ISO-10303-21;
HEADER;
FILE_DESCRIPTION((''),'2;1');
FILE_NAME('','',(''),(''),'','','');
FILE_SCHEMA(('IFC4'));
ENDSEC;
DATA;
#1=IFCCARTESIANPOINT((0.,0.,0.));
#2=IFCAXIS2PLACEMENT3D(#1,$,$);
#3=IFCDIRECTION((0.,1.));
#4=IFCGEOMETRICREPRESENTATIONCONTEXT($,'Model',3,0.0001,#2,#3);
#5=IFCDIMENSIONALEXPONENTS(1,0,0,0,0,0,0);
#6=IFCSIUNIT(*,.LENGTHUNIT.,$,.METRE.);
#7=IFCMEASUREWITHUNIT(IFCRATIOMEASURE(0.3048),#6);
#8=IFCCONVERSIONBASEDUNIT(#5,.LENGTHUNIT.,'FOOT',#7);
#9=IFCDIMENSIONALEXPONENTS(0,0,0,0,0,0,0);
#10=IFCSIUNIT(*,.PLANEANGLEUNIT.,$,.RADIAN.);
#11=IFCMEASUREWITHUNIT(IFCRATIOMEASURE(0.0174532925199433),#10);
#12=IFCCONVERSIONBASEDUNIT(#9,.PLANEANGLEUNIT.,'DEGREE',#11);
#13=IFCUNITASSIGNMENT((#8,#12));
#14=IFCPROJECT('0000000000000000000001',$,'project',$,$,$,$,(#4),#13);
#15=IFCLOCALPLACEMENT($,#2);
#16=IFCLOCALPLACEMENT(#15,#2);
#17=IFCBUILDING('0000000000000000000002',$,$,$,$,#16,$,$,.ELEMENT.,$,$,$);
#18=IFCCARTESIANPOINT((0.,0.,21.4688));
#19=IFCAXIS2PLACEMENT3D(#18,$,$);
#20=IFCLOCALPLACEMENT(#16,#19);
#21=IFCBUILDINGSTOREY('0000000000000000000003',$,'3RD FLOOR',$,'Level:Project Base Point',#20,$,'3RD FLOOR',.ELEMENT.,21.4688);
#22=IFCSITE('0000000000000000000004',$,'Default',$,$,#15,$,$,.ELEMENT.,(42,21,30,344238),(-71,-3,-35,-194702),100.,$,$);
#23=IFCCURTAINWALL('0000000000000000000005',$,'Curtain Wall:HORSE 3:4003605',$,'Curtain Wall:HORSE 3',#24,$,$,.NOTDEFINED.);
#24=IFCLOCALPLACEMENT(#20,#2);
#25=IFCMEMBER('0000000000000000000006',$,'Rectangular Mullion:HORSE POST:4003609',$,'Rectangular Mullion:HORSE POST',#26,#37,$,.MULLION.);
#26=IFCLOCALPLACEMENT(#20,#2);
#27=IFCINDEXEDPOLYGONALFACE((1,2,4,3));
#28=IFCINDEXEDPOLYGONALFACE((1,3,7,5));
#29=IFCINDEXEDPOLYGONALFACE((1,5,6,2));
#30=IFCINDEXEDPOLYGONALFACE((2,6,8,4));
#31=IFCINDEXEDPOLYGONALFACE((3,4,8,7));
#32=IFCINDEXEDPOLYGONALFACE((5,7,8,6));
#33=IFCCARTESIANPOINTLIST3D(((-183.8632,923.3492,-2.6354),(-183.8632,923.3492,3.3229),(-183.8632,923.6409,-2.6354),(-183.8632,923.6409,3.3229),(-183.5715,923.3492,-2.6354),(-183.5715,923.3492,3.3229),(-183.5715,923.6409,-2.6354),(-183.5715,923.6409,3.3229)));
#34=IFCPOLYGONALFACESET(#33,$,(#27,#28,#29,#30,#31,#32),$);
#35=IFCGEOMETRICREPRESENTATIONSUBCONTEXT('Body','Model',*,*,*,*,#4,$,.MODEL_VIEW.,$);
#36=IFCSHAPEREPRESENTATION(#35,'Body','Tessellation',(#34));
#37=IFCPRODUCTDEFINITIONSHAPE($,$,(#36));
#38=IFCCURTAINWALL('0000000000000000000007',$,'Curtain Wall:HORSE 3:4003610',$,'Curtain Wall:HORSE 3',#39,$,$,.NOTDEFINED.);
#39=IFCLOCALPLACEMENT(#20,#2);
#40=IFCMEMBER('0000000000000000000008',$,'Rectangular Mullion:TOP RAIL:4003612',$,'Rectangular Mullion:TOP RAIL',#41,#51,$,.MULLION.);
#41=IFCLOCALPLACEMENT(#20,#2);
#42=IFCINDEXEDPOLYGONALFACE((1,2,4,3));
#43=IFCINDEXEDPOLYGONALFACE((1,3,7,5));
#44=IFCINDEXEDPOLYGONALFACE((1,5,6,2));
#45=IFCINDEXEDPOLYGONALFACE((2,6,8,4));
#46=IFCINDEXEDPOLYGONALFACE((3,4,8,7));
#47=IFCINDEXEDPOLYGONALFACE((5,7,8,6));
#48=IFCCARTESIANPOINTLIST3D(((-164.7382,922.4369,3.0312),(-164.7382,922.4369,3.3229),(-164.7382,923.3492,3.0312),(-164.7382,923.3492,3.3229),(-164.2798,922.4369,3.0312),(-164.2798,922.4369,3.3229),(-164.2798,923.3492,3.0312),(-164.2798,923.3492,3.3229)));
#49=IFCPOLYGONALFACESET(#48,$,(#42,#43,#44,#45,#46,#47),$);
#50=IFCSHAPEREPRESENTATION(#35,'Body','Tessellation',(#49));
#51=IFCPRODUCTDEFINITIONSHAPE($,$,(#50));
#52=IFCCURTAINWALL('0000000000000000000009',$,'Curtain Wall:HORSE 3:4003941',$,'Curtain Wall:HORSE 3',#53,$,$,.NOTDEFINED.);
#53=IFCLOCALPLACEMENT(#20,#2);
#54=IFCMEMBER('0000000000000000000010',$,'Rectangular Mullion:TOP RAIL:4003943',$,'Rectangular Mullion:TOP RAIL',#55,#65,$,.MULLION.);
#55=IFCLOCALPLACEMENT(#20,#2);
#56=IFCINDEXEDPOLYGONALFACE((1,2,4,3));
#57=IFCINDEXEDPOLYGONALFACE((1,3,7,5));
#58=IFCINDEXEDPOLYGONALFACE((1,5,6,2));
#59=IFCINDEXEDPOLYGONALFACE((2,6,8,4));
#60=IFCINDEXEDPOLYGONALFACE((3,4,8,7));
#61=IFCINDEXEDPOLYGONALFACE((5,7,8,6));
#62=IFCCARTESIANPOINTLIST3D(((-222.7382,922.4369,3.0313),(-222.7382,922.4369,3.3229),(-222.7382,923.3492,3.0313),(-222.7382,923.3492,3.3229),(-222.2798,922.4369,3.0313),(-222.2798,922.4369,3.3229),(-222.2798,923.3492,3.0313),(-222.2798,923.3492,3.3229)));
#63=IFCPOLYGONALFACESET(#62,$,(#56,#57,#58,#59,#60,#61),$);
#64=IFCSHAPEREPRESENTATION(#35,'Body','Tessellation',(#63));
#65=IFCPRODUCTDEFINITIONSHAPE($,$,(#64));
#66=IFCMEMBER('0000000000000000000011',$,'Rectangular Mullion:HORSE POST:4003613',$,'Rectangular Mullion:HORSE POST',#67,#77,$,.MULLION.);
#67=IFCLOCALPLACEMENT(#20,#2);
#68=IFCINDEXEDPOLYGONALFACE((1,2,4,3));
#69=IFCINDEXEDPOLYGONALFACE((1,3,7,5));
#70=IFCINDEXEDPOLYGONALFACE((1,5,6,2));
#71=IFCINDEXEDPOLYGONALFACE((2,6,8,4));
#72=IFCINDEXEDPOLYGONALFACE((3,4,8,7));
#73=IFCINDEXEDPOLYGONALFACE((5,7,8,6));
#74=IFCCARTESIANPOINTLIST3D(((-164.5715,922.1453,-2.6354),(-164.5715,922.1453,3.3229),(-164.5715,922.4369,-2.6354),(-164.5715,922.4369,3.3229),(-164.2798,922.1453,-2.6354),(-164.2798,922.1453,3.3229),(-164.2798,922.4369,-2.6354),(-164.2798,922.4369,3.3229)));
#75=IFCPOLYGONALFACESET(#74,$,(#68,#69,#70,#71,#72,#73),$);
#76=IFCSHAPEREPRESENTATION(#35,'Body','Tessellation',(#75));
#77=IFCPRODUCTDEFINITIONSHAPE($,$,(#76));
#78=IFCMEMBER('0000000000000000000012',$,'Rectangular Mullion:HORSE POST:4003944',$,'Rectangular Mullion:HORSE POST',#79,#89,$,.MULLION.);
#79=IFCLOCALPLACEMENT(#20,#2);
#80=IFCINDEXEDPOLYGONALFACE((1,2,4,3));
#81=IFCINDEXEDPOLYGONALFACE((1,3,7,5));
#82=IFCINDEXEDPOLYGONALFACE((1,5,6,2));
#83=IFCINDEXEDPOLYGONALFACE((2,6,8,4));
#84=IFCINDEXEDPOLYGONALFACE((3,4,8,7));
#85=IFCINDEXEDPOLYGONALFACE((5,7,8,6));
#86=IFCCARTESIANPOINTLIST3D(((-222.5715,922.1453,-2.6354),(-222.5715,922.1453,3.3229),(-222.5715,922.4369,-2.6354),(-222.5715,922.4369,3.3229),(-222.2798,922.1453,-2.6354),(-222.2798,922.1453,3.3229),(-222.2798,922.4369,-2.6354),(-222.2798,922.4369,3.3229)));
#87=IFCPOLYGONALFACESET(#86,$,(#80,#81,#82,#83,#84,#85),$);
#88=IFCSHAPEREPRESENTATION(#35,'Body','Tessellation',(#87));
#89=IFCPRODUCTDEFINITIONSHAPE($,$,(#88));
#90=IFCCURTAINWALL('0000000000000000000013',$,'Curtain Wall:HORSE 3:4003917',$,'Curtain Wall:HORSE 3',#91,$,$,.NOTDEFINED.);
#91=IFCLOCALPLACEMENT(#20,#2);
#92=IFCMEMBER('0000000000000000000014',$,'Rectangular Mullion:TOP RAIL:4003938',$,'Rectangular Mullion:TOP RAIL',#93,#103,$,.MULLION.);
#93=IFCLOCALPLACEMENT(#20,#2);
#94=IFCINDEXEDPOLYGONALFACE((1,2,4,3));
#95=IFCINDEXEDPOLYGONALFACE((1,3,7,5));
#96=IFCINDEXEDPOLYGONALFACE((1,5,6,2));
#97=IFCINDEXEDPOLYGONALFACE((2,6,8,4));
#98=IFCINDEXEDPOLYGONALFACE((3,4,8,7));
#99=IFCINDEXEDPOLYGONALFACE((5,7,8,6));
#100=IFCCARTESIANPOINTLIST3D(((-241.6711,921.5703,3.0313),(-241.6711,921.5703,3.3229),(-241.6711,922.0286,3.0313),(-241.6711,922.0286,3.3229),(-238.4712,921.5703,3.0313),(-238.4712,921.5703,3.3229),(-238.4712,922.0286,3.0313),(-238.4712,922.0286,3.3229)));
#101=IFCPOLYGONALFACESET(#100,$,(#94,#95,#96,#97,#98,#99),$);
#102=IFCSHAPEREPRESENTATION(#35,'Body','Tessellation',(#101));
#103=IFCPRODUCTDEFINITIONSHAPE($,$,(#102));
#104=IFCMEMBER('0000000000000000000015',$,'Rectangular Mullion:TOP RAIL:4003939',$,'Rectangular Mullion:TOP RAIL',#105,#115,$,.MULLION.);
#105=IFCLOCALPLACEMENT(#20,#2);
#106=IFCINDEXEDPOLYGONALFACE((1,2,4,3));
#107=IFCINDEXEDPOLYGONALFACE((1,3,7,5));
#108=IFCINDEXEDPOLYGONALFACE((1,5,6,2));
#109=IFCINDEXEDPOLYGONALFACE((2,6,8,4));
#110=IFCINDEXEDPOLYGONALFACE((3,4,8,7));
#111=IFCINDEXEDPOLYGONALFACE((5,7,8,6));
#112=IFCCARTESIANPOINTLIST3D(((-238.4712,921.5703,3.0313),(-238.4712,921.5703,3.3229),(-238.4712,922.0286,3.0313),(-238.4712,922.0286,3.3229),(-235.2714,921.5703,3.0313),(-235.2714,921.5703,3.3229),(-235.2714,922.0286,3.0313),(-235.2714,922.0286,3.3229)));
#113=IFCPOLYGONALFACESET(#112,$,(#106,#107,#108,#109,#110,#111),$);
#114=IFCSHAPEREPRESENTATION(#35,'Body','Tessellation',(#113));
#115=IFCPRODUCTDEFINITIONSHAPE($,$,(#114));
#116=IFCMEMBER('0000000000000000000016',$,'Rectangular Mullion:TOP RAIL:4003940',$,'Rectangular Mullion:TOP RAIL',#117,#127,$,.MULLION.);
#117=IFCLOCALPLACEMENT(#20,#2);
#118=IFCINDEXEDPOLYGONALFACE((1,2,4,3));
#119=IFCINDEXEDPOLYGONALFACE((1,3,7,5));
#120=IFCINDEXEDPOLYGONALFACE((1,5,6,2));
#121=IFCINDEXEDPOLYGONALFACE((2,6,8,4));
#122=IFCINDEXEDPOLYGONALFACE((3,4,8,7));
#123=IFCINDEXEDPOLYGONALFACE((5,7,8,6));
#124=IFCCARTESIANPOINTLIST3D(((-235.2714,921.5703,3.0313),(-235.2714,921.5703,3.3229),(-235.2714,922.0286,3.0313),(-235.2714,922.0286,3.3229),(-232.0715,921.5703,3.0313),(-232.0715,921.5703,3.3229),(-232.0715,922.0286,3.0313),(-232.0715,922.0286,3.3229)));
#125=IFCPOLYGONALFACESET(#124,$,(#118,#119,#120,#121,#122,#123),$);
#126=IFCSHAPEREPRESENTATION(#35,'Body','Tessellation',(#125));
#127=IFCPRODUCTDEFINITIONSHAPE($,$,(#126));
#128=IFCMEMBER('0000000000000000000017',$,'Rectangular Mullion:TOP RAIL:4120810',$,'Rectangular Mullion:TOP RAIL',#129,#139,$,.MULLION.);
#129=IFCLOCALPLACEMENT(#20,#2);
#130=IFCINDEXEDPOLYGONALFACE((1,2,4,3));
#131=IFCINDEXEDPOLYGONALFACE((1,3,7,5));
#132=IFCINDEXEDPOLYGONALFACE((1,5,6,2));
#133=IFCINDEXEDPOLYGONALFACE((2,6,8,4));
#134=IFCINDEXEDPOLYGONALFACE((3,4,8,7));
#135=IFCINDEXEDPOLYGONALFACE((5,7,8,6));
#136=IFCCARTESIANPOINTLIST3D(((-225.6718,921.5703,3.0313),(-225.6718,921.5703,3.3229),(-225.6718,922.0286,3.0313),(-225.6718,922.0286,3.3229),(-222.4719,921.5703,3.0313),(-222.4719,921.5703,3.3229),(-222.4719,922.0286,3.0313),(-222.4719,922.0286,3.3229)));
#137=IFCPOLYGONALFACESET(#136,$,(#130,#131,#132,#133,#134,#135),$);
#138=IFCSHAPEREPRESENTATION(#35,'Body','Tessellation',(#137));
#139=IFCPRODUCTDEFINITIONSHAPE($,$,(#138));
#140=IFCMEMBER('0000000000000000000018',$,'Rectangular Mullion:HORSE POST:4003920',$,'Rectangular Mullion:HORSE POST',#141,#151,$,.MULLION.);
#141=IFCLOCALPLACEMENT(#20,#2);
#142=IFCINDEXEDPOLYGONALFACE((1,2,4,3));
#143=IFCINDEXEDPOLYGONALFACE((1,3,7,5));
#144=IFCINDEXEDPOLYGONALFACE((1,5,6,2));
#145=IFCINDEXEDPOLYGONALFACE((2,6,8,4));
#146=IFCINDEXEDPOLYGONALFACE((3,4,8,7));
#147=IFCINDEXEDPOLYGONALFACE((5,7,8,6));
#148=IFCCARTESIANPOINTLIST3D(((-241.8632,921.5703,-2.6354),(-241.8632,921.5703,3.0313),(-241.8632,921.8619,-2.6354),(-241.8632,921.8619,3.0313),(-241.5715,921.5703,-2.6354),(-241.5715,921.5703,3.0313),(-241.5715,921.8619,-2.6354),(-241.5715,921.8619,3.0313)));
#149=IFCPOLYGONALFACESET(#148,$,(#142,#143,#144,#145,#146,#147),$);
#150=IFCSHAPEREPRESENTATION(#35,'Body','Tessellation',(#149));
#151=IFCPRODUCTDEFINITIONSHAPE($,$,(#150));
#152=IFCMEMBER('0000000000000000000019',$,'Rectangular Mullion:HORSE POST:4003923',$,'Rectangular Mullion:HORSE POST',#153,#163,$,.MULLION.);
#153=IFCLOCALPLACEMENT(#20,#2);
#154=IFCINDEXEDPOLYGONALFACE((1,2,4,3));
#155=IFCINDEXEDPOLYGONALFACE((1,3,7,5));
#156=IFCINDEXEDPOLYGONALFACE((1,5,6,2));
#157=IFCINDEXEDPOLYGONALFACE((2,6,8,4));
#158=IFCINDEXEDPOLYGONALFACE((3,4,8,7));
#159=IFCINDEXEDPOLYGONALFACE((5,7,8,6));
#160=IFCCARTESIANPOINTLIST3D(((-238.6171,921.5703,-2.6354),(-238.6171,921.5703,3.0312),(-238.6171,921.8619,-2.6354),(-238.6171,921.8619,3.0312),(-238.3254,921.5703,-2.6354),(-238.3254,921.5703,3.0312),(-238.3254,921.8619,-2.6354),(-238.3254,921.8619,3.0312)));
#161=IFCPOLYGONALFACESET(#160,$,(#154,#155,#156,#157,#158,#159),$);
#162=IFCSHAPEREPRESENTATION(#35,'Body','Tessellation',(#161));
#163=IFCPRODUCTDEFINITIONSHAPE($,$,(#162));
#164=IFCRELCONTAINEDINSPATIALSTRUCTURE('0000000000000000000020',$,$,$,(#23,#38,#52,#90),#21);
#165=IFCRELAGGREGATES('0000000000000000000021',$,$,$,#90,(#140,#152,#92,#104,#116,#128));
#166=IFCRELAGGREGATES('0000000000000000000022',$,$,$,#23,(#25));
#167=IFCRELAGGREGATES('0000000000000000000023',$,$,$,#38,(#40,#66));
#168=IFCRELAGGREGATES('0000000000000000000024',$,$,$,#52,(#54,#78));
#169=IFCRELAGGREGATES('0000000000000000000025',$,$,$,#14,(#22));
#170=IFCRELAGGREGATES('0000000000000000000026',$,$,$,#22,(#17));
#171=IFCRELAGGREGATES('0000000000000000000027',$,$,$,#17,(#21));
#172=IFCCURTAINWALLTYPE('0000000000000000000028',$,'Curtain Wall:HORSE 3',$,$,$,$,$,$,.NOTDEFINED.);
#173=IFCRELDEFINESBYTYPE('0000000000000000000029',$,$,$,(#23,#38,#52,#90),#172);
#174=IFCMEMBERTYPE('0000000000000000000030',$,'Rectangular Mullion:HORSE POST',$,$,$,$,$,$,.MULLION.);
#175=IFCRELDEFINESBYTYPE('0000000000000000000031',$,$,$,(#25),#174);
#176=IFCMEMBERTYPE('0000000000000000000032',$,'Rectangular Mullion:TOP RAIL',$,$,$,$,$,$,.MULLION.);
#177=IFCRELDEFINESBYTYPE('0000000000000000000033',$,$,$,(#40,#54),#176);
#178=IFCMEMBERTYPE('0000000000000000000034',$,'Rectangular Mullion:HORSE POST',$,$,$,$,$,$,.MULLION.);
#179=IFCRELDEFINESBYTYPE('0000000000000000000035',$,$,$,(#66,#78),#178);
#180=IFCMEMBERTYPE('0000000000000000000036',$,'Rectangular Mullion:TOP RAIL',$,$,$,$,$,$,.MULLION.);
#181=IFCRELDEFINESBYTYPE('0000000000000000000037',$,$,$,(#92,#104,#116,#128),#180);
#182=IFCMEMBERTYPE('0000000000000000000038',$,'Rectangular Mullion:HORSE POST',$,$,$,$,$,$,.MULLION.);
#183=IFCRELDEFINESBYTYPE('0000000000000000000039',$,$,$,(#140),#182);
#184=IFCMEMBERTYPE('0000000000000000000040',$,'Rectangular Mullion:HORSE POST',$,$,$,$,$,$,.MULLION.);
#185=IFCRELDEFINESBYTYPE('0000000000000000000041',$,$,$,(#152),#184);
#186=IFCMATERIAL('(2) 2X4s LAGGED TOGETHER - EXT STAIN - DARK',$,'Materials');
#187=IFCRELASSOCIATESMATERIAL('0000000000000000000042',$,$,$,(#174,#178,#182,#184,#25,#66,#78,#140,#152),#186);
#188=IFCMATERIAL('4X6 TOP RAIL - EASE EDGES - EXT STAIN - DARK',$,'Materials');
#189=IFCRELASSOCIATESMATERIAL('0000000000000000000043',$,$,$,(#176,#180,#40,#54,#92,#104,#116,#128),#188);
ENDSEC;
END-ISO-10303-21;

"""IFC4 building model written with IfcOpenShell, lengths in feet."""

from ifc_helpers import new_model, entity, si_unit, converted_unit, direction, frame, frame_2d, origin, origin_2d_with_axis, place, context, subcontext, project, spatial, rectangle, extrude, source, transform, mapped, material, material_profile, profile_set, profile_usage, type_object, type_shapes, element, aggregate, save


model = new_model("IFC4")

# Units and contexts
model_context = context("Model", 3, precision=0.0001, world=origin(), true_north=direction((0.0, 1.0)))
body_context = subcontext(model_context, "Body", "Model", "MODEL_VIEW")
ifc_project = project(units=[converted_unit("LENGTHUNIT", "FOOT", entity("IfcRatioMeasure", 0.3048), si_unit("LENGTHUNIT", "METRE"), dimensions=[1, 0, 0, 0, 0, 0, 0]), converted_unit("PLANEANGLEUNIT", "DEGREE", entity("IfcRatioMeasure", 0.0174532925199433), si_unit("PLANEANGLEUNIT", "RADIAN"), dimensions=[0, 0, 0, 0, 0, 0, 0])], contexts=[model_context])

# Site, building, storey
site_placement = place(None, origin())
site = spatial("IfcSite", under=ifc_project, at=site_placement, Name="Default", CompositionType="ELEMENT", RefLatitude=(42, 21, 30, 344238), RefLongitude=(-71, -3, -35, -194702), RefElevation=100.0)
building_placement = place(site_placement, origin())
building = spatial("IfcBuilding", under=site, at=building_placement, CompositionType="ELEMENT")
storey_placement = place(building_placement, frame((0.0, 0.0, 21.4688)))
storey = spatial("IfcBuildingStorey", under=building, at=storey_placement, Name="3RD FLOOR", ObjectType="Level:Project Base Point", LongName="3RD FLOOR", CompositionType="ELEMENT", Elevation=21.4688)

# Shared definitions
curtain_wall_type = type_object("IfcCurtainWallType", Name="Curtain Wall:HORSE 3", PredefinedType="NOTDEFINED")
ifc_material_1 = material(Name="(2) 2X4s LAGGED TOGETHER - EXT STAIN - DARK", Category="Materials")
ifc_material_profile_1 = material_profile(ifc_material_1, rectangle(XDim=0.2917, YDim=0.2917, at=frame_2d((0.0, 0.0), x_axis=(1.0, 0.0))), Name="HORSE POST")
ifc_profile_set_1 = profile_set([ifc_material_profile_1], Name="HORSE POST")
ifc_material_2 = material(Name="4X6 TOP RAIL - EASE EDGES - EXT STAIN - DARK", Category="Materials")
ifc_material_profile_2 = material_profile(ifc_material_2, rectangle(XDim=0.4583, YDim=0.2917, at=origin_2d_with_axis()), Name="TOP RAIL")
ifc_profile_set_2 = profile_set([ifc_material_profile_2], Name="TOP RAIL")

# Curtain wall
curtain_wall_1_placement = place(storey_placement, frame((0.0, 0.0, -21.4688)))
curtain_wall_1 = element("IfcCurtainWall", 1, at=curtain_wall_1_placement, inside=storey, type_object=curtain_wall_type, Name="Curtain Wall:HORSE 3:4003605", ObjectType="Curtain Wall:HORSE 3", PredefinedType="NOTDEFINED")

# Member
ifc_profile_usage_1 = profile_usage(ifc_profile_set_1)
member_type_1 = type_object("IfcMemberType", Name="Rectangular Mullion:HORSE POST", PredefinedType="MULLION", material=ifc_profile_set_1)
shared_shape_1 = source(origin(), body_context, "Body", "SweptSolid", [
    extrude(rectangle(XDim=0.2917, YDim=0.2917, at=origin_2d_with_axis()), frame((-0.1458, 0.1458, -5.9583), z_axis=(0.0, 0.0, 1.0), x_axis=(0.0, -1.0, 0.0)), (0.0, 0.0, 1.0), 5.9583),
])
type_shapes(member_type_1, [shared_shape_1])
member_1_placement = place(storey_placement, frame((-183.5715, 923.6409, 3.3229), z_axis=(0.0, 0.0, 1.0), x_axis=(0.0, 1.0, 0.0)))
member_1 = element("IfcMember", 2, at=member_1_placement, type_object=member_type_1, material=ifc_profile_usage_1, Name="Rectangular Mullion:HORSE POST:4003609", ObjectType="Rectangular Mullion:HORSE POST", PredefinedType="MULLION", context=body_context, shape_type="MappedRepresentation", body=[
    mapped(shared_shape_1, transform((0.0, 0.0, 0.0), scale=1.0)),
])

# Curtain walls, members
curtain_wall_2_placement = place(storey_placement, frame((0.0, 0.0, -21.4688)))
curtain_wall_2 = element("IfcCurtainWall", 3, at=curtain_wall_2_placement, inside=storey, type_object=curtain_wall_type, Name="Curtain Wall:HORSE 3:4003610", ObjectType="Curtain Wall:HORSE 3", PredefinedType="NOTDEFINED")
ifc_profile_usage_2 = profile_usage(ifc_profile_set_2)
member_type_2 = type_object("IfcMemberType", Name="Rectangular Mullion:TOP RAIL", PredefinedType="MULLION", material=ifc_profile_set_2)
shared_shape_2 = source(origin(), body_context, "Body", "SweptSolid", [
    extrude(rectangle(XDim=0.4583, YDim=0.2917, at=origin_2d_with_axis()), frame((-0.1458, -0.0625, -0.9123), z_axis=(0.0, 0.0, 1.0), x_axis=(0.0, -1.0, 0.0)), (0.0, 0.0, 1.0), 0.9123),
])
type_shapes(member_type_2, [shared_shape_2])
member_2_placement = place(storey_placement, frame((-164.5715, 922.4369, 3.3229), z_axis=(0.0, -1.0, 0.0), x_axis=(0.0, 0.0, 1.0)))
member_2 = element("IfcMember", 4, at=member_2_placement, type_object=member_type_2, material=ifc_profile_usage_2, Name="Rectangular Mullion:TOP RAIL:4003612", ObjectType="Rectangular Mullion:TOP RAIL", PredefinedType="MULLION", context=body_context, shape_type="MappedRepresentation", body=[
    mapped(shared_shape_2, transform((0.0, 0.0, 0.0), scale=1.0)),
])
curtain_wall_3_placement = place(storey_placement, frame((0.0, 0.0, -21.4688)))
curtain_wall_3 = element("IfcCurtainWall", 5, at=curtain_wall_3_placement, inside=storey, type_object=curtain_wall_type, Name="Curtain Wall:HORSE 3:4003941", ObjectType="Curtain Wall:HORSE 3", PredefinedType="NOTDEFINED")
ifc_profile_usage_3 = profile_usage(ifc_profile_set_2)
member_3_placement = place(storey_placement, frame((-222.5715, 922.4369, 3.3229), z_axis=(0.0, -1.0, 0.0), x_axis=(0.0, 0.0, 1.0)))
member_3 = element("IfcMember", 6, at=member_3_placement, type_object=member_type_2, material=ifc_profile_usage_3, Name="Rectangular Mullion:TOP RAIL:4003943", ObjectType="Rectangular Mullion:TOP RAIL", PredefinedType="MULLION", context=body_context, shape_type="MappedRepresentation", body=[
    mapped(shared_shape_2, transform((0.0, 0.0, 0.0), scale=1.0)),
])

# Members
ifc_profile_usage_4 = profile_usage(ifc_profile_set_1)
member_type_3 = type_object("IfcMemberType", Name="Rectangular Mullion:HORSE POST", PredefinedType="MULLION", material=ifc_profile_set_1)
shared_shape_3 = source(origin(), body_context, "Body", "SweptSolid", [
    extrude(rectangle(XDim=0.2917, YDim=0.2917, at=origin_2d_with_axis()), frame((-0.1458, -0.1458, -5.9583), z_axis=(0.0, 0.0, 1.0), x_axis=(0.0, -1.0, 0.0)), (0.0, 0.0, 1.0), 5.9583),
])
type_shapes(member_type_3, [shared_shape_3])
member_4_placement = place(storey_placement, frame((-164.5715, 922.1453, -2.6354), z_axis=(0.0, 0.0, -1.0), x_axis=(0.0, -1.0, 0.0)))
member_4 = element("IfcMember", 7, at=member_4_placement, type_object=member_type_3, material=ifc_profile_usage_4, Name="Rectangular Mullion:HORSE POST:4003613", ObjectType="Rectangular Mullion:HORSE POST", PredefinedType="MULLION", context=body_context, shape_type="MappedRepresentation", body=[
    mapped(shared_shape_3, transform((0.0, 0.0, 0.0), scale=1.0)),
])
ifc_profile_usage_5 = profile_usage(ifc_profile_set_1)
member_5_placement = place(storey_placement, frame((-222.5715, 922.1453, -2.6354), z_axis=(0.0, 0.0, -1.0), x_axis=(0.0, -1.0, 0.0)))
member_5 = element("IfcMember", 8, at=member_5_placement, type_object=member_type_3, material=ifc_profile_usage_5, Name="Rectangular Mullion:HORSE POST:4003944", ObjectType="Rectangular Mullion:HORSE POST", PredefinedType="MULLION", context=body_context, shape_type="MappedRepresentation", body=[
    mapped(shared_shape_3, transform((0.0, 0.0, 0.0), scale=1.0)),
])

# Curtain wall, members
curtain_wall_4_placement = place(storey_placement, frame((0.0, 0.0, -21.4688)))
curtain_wall_4 = element("IfcCurtainWall", 9, at=curtain_wall_4_placement, inside=storey, type_object=curtain_wall_type, Name="Curtain Wall:HORSE 3:4003917", ObjectType="Curtain Wall:HORSE 3", PredefinedType="NOTDEFINED")
ifc_profile_usage_6 = profile_usage(ifc_profile_set_2)
member_type_4 = type_object("IfcMemberType", Name="Rectangular Mullion:TOP RAIL", PredefinedType="MULLION", material=ifc_profile_set_2)
shared_shape_4 = source(origin(), body_context, "Body", "SweptSolid", [
    extrude(rectangle(XDim=0.4583, YDim=0.2917, at=origin_2d_with_axis()), frame((-0.1458, 0.0625, -3.1999), z_axis=(0.0, 0.0, 1.0), x_axis=(0.0, -1.0, 0.0)), (0.0, 0.0, 1.0), 3.1999),
])
type_shapes(member_type_4, [shared_shape_4])
member_6_placement = place(storey_placement, frame((-238.4712, 921.8619, 3.3229), z_axis=(1.0, 0.0, 0.0), x_axis=(0.0, 0.0, 1.0)))
member_6 = element("IfcMember", 10, at=member_6_placement, type_object=member_type_4, material=ifc_profile_usage_6, Name="Rectangular Mullion:TOP RAIL:4003938", ObjectType="Rectangular Mullion:TOP RAIL", PredefinedType="MULLION", context=body_context, shape_type="MappedRepresentation", body=[
    mapped(shared_shape_4, transform((0.0, 0.0, 0.0), scale=1.0)),
])
ifc_profile_usage_7 = profile_usage(ifc_profile_set_2)
member_7_placement = place(storey_placement, frame((-235.2714, 921.8619, 3.3229), z_axis=(1.0, 0.0, 0.0), x_axis=(0.0, 0.0, 1.0)))
member_7 = element("IfcMember", 11, at=member_7_placement, type_object=member_type_4, material=ifc_profile_usage_7, Name="Rectangular Mullion:TOP RAIL:4003939", ObjectType="Rectangular Mullion:TOP RAIL", PredefinedType="MULLION", context=body_context, shape_type="MappedRepresentation", body=[
    mapped(shared_shape_4, transform((0.0, 0.0, 0.0), scale=1.0)),
])
ifc_profile_usage_8 = profile_usage(ifc_profile_set_2)
member_8_placement = place(storey_placement, frame((-232.0715, 921.8619, 3.3229), z_axis=(1.0, 0.0, 0.0), x_axis=(0.0, 0.0, 1.0)))
member_8 = element("IfcMember", 12, at=member_8_placement, type_object=member_type_4, material=ifc_profile_usage_8, Name="Rectangular Mullion:TOP RAIL:4003940", ObjectType="Rectangular Mullion:TOP RAIL", PredefinedType="MULLION", context=body_context, shape_type="MappedRepresentation", body=[
    mapped(shared_shape_4, transform((0.0, 0.0, 0.0), scale=1.0)),
])
ifc_profile_usage_9 = profile_usage(ifc_profile_set_2)
member_9_placement = place(storey_placement, frame((-222.4719, 921.8619, 3.3229), z_axis=(1.0, 0.0, 0.0), x_axis=(0.0, 0.0, 1.0)))
member_9 = element("IfcMember", 13, at=member_9_placement, type_object=member_type_4, material=ifc_profile_usage_9, Name="Rectangular Mullion:TOP RAIL:4120810", ObjectType="Rectangular Mullion:TOP RAIL", PredefinedType="MULLION", context=body_context, shape_type="MappedRepresentation", body=[
    mapped(shared_shape_4, transform((0.0, 0.0, 0.0), scale=1.0)),
])
ifc_profile_usage_10 = profile_usage(ifc_profile_set_1)
member_type_5 = type_object("IfcMemberType", Name="Rectangular Mullion:HORSE POST", PredefinedType="MULLION", material=ifc_profile_set_1)
shared_shape_5 = source(origin(), body_context, "Body", "SweptSolid", [
    extrude(rectangle(XDim=0.2917, YDim=0.2917, at=origin_2d_with_axis()), frame((-0.1458, 0.1458, -5.6667), z_axis=(0.0, 0.0, 1.0), x_axis=(0.0, -1.0, 0.0)), (0.0, 0.0, 1.0), 5.6667),
])
type_shapes(member_type_5, [shared_shape_5])
member_10_placement = place(storey_placement, frame((-241.8632, 921.8619, 3.0313), z_axis=(0.0, 0.0, 1.0), x_axis=(-1.0, 0.0, 0.0)))
member_10 = element("IfcMember", 14, at=member_10_placement, type_object=member_type_5, material=ifc_profile_usage_10, Name="Rectangular Mullion:HORSE POST:4003920", ObjectType="Rectangular Mullion:HORSE POST", PredefinedType="MULLION", context=body_context, shape_type="MappedRepresentation", body=[
    mapped(shared_shape_5, transform((0.0, 0.0, 0.0), scale=1.0)),
])
ifc_profile_usage_11 = profile_usage(ifc_profile_set_1)
member_type_6 = type_object("IfcMemberType", Name="Rectangular Mullion:HORSE POST", PredefinedType="MULLION", material=ifc_profile_set_1)
shared_shape_6 = source(origin(), body_context, "Body", "SweptSolid", [
    extrude(rectangle(XDim=0.2917, YDim=0.2917, at=origin_2d_with_axis()), frame((0.0, 0.1458, -5.6667), z_axis=(0.0, 0.0, 1.0), x_axis=(0.0, -1.0, 0.0)), (0.0, 0.0, 1.0), 5.6667),
])
type_shapes(member_type_6, [shared_shape_6])
member_11_placement = place(storey_placement, frame((-238.4712, 921.8619, -2.6354), z_axis=(0.0, 0.0, -1.0), x_axis=(1.0, 0.0, 0.0)))
member_11 = element("IfcMember", 15, at=member_11_placement, type_object=member_type_6, material=ifc_profile_usage_11, Name="Rectangular Mullion:HORSE POST:4003923", ObjectType="Rectangular Mullion:HORSE POST", PredefinedType="MULLION", context=body_context, shape_type="MappedRepresentation", body=[
    mapped(shared_shape_6, transform((0.0, 0.0, 0.0), scale=1.0)),
])
aggregate(curtain_wall_4, [member_10, member_11, member_6, member_7, member_8, member_9])

aggregate(curtain_wall_1, [member_1])
aggregate(curtain_wall_2, [member_2, member_4])
aggregate(curtain_wall_3, [member_3, member_5])

save(model, "model.ifc")
